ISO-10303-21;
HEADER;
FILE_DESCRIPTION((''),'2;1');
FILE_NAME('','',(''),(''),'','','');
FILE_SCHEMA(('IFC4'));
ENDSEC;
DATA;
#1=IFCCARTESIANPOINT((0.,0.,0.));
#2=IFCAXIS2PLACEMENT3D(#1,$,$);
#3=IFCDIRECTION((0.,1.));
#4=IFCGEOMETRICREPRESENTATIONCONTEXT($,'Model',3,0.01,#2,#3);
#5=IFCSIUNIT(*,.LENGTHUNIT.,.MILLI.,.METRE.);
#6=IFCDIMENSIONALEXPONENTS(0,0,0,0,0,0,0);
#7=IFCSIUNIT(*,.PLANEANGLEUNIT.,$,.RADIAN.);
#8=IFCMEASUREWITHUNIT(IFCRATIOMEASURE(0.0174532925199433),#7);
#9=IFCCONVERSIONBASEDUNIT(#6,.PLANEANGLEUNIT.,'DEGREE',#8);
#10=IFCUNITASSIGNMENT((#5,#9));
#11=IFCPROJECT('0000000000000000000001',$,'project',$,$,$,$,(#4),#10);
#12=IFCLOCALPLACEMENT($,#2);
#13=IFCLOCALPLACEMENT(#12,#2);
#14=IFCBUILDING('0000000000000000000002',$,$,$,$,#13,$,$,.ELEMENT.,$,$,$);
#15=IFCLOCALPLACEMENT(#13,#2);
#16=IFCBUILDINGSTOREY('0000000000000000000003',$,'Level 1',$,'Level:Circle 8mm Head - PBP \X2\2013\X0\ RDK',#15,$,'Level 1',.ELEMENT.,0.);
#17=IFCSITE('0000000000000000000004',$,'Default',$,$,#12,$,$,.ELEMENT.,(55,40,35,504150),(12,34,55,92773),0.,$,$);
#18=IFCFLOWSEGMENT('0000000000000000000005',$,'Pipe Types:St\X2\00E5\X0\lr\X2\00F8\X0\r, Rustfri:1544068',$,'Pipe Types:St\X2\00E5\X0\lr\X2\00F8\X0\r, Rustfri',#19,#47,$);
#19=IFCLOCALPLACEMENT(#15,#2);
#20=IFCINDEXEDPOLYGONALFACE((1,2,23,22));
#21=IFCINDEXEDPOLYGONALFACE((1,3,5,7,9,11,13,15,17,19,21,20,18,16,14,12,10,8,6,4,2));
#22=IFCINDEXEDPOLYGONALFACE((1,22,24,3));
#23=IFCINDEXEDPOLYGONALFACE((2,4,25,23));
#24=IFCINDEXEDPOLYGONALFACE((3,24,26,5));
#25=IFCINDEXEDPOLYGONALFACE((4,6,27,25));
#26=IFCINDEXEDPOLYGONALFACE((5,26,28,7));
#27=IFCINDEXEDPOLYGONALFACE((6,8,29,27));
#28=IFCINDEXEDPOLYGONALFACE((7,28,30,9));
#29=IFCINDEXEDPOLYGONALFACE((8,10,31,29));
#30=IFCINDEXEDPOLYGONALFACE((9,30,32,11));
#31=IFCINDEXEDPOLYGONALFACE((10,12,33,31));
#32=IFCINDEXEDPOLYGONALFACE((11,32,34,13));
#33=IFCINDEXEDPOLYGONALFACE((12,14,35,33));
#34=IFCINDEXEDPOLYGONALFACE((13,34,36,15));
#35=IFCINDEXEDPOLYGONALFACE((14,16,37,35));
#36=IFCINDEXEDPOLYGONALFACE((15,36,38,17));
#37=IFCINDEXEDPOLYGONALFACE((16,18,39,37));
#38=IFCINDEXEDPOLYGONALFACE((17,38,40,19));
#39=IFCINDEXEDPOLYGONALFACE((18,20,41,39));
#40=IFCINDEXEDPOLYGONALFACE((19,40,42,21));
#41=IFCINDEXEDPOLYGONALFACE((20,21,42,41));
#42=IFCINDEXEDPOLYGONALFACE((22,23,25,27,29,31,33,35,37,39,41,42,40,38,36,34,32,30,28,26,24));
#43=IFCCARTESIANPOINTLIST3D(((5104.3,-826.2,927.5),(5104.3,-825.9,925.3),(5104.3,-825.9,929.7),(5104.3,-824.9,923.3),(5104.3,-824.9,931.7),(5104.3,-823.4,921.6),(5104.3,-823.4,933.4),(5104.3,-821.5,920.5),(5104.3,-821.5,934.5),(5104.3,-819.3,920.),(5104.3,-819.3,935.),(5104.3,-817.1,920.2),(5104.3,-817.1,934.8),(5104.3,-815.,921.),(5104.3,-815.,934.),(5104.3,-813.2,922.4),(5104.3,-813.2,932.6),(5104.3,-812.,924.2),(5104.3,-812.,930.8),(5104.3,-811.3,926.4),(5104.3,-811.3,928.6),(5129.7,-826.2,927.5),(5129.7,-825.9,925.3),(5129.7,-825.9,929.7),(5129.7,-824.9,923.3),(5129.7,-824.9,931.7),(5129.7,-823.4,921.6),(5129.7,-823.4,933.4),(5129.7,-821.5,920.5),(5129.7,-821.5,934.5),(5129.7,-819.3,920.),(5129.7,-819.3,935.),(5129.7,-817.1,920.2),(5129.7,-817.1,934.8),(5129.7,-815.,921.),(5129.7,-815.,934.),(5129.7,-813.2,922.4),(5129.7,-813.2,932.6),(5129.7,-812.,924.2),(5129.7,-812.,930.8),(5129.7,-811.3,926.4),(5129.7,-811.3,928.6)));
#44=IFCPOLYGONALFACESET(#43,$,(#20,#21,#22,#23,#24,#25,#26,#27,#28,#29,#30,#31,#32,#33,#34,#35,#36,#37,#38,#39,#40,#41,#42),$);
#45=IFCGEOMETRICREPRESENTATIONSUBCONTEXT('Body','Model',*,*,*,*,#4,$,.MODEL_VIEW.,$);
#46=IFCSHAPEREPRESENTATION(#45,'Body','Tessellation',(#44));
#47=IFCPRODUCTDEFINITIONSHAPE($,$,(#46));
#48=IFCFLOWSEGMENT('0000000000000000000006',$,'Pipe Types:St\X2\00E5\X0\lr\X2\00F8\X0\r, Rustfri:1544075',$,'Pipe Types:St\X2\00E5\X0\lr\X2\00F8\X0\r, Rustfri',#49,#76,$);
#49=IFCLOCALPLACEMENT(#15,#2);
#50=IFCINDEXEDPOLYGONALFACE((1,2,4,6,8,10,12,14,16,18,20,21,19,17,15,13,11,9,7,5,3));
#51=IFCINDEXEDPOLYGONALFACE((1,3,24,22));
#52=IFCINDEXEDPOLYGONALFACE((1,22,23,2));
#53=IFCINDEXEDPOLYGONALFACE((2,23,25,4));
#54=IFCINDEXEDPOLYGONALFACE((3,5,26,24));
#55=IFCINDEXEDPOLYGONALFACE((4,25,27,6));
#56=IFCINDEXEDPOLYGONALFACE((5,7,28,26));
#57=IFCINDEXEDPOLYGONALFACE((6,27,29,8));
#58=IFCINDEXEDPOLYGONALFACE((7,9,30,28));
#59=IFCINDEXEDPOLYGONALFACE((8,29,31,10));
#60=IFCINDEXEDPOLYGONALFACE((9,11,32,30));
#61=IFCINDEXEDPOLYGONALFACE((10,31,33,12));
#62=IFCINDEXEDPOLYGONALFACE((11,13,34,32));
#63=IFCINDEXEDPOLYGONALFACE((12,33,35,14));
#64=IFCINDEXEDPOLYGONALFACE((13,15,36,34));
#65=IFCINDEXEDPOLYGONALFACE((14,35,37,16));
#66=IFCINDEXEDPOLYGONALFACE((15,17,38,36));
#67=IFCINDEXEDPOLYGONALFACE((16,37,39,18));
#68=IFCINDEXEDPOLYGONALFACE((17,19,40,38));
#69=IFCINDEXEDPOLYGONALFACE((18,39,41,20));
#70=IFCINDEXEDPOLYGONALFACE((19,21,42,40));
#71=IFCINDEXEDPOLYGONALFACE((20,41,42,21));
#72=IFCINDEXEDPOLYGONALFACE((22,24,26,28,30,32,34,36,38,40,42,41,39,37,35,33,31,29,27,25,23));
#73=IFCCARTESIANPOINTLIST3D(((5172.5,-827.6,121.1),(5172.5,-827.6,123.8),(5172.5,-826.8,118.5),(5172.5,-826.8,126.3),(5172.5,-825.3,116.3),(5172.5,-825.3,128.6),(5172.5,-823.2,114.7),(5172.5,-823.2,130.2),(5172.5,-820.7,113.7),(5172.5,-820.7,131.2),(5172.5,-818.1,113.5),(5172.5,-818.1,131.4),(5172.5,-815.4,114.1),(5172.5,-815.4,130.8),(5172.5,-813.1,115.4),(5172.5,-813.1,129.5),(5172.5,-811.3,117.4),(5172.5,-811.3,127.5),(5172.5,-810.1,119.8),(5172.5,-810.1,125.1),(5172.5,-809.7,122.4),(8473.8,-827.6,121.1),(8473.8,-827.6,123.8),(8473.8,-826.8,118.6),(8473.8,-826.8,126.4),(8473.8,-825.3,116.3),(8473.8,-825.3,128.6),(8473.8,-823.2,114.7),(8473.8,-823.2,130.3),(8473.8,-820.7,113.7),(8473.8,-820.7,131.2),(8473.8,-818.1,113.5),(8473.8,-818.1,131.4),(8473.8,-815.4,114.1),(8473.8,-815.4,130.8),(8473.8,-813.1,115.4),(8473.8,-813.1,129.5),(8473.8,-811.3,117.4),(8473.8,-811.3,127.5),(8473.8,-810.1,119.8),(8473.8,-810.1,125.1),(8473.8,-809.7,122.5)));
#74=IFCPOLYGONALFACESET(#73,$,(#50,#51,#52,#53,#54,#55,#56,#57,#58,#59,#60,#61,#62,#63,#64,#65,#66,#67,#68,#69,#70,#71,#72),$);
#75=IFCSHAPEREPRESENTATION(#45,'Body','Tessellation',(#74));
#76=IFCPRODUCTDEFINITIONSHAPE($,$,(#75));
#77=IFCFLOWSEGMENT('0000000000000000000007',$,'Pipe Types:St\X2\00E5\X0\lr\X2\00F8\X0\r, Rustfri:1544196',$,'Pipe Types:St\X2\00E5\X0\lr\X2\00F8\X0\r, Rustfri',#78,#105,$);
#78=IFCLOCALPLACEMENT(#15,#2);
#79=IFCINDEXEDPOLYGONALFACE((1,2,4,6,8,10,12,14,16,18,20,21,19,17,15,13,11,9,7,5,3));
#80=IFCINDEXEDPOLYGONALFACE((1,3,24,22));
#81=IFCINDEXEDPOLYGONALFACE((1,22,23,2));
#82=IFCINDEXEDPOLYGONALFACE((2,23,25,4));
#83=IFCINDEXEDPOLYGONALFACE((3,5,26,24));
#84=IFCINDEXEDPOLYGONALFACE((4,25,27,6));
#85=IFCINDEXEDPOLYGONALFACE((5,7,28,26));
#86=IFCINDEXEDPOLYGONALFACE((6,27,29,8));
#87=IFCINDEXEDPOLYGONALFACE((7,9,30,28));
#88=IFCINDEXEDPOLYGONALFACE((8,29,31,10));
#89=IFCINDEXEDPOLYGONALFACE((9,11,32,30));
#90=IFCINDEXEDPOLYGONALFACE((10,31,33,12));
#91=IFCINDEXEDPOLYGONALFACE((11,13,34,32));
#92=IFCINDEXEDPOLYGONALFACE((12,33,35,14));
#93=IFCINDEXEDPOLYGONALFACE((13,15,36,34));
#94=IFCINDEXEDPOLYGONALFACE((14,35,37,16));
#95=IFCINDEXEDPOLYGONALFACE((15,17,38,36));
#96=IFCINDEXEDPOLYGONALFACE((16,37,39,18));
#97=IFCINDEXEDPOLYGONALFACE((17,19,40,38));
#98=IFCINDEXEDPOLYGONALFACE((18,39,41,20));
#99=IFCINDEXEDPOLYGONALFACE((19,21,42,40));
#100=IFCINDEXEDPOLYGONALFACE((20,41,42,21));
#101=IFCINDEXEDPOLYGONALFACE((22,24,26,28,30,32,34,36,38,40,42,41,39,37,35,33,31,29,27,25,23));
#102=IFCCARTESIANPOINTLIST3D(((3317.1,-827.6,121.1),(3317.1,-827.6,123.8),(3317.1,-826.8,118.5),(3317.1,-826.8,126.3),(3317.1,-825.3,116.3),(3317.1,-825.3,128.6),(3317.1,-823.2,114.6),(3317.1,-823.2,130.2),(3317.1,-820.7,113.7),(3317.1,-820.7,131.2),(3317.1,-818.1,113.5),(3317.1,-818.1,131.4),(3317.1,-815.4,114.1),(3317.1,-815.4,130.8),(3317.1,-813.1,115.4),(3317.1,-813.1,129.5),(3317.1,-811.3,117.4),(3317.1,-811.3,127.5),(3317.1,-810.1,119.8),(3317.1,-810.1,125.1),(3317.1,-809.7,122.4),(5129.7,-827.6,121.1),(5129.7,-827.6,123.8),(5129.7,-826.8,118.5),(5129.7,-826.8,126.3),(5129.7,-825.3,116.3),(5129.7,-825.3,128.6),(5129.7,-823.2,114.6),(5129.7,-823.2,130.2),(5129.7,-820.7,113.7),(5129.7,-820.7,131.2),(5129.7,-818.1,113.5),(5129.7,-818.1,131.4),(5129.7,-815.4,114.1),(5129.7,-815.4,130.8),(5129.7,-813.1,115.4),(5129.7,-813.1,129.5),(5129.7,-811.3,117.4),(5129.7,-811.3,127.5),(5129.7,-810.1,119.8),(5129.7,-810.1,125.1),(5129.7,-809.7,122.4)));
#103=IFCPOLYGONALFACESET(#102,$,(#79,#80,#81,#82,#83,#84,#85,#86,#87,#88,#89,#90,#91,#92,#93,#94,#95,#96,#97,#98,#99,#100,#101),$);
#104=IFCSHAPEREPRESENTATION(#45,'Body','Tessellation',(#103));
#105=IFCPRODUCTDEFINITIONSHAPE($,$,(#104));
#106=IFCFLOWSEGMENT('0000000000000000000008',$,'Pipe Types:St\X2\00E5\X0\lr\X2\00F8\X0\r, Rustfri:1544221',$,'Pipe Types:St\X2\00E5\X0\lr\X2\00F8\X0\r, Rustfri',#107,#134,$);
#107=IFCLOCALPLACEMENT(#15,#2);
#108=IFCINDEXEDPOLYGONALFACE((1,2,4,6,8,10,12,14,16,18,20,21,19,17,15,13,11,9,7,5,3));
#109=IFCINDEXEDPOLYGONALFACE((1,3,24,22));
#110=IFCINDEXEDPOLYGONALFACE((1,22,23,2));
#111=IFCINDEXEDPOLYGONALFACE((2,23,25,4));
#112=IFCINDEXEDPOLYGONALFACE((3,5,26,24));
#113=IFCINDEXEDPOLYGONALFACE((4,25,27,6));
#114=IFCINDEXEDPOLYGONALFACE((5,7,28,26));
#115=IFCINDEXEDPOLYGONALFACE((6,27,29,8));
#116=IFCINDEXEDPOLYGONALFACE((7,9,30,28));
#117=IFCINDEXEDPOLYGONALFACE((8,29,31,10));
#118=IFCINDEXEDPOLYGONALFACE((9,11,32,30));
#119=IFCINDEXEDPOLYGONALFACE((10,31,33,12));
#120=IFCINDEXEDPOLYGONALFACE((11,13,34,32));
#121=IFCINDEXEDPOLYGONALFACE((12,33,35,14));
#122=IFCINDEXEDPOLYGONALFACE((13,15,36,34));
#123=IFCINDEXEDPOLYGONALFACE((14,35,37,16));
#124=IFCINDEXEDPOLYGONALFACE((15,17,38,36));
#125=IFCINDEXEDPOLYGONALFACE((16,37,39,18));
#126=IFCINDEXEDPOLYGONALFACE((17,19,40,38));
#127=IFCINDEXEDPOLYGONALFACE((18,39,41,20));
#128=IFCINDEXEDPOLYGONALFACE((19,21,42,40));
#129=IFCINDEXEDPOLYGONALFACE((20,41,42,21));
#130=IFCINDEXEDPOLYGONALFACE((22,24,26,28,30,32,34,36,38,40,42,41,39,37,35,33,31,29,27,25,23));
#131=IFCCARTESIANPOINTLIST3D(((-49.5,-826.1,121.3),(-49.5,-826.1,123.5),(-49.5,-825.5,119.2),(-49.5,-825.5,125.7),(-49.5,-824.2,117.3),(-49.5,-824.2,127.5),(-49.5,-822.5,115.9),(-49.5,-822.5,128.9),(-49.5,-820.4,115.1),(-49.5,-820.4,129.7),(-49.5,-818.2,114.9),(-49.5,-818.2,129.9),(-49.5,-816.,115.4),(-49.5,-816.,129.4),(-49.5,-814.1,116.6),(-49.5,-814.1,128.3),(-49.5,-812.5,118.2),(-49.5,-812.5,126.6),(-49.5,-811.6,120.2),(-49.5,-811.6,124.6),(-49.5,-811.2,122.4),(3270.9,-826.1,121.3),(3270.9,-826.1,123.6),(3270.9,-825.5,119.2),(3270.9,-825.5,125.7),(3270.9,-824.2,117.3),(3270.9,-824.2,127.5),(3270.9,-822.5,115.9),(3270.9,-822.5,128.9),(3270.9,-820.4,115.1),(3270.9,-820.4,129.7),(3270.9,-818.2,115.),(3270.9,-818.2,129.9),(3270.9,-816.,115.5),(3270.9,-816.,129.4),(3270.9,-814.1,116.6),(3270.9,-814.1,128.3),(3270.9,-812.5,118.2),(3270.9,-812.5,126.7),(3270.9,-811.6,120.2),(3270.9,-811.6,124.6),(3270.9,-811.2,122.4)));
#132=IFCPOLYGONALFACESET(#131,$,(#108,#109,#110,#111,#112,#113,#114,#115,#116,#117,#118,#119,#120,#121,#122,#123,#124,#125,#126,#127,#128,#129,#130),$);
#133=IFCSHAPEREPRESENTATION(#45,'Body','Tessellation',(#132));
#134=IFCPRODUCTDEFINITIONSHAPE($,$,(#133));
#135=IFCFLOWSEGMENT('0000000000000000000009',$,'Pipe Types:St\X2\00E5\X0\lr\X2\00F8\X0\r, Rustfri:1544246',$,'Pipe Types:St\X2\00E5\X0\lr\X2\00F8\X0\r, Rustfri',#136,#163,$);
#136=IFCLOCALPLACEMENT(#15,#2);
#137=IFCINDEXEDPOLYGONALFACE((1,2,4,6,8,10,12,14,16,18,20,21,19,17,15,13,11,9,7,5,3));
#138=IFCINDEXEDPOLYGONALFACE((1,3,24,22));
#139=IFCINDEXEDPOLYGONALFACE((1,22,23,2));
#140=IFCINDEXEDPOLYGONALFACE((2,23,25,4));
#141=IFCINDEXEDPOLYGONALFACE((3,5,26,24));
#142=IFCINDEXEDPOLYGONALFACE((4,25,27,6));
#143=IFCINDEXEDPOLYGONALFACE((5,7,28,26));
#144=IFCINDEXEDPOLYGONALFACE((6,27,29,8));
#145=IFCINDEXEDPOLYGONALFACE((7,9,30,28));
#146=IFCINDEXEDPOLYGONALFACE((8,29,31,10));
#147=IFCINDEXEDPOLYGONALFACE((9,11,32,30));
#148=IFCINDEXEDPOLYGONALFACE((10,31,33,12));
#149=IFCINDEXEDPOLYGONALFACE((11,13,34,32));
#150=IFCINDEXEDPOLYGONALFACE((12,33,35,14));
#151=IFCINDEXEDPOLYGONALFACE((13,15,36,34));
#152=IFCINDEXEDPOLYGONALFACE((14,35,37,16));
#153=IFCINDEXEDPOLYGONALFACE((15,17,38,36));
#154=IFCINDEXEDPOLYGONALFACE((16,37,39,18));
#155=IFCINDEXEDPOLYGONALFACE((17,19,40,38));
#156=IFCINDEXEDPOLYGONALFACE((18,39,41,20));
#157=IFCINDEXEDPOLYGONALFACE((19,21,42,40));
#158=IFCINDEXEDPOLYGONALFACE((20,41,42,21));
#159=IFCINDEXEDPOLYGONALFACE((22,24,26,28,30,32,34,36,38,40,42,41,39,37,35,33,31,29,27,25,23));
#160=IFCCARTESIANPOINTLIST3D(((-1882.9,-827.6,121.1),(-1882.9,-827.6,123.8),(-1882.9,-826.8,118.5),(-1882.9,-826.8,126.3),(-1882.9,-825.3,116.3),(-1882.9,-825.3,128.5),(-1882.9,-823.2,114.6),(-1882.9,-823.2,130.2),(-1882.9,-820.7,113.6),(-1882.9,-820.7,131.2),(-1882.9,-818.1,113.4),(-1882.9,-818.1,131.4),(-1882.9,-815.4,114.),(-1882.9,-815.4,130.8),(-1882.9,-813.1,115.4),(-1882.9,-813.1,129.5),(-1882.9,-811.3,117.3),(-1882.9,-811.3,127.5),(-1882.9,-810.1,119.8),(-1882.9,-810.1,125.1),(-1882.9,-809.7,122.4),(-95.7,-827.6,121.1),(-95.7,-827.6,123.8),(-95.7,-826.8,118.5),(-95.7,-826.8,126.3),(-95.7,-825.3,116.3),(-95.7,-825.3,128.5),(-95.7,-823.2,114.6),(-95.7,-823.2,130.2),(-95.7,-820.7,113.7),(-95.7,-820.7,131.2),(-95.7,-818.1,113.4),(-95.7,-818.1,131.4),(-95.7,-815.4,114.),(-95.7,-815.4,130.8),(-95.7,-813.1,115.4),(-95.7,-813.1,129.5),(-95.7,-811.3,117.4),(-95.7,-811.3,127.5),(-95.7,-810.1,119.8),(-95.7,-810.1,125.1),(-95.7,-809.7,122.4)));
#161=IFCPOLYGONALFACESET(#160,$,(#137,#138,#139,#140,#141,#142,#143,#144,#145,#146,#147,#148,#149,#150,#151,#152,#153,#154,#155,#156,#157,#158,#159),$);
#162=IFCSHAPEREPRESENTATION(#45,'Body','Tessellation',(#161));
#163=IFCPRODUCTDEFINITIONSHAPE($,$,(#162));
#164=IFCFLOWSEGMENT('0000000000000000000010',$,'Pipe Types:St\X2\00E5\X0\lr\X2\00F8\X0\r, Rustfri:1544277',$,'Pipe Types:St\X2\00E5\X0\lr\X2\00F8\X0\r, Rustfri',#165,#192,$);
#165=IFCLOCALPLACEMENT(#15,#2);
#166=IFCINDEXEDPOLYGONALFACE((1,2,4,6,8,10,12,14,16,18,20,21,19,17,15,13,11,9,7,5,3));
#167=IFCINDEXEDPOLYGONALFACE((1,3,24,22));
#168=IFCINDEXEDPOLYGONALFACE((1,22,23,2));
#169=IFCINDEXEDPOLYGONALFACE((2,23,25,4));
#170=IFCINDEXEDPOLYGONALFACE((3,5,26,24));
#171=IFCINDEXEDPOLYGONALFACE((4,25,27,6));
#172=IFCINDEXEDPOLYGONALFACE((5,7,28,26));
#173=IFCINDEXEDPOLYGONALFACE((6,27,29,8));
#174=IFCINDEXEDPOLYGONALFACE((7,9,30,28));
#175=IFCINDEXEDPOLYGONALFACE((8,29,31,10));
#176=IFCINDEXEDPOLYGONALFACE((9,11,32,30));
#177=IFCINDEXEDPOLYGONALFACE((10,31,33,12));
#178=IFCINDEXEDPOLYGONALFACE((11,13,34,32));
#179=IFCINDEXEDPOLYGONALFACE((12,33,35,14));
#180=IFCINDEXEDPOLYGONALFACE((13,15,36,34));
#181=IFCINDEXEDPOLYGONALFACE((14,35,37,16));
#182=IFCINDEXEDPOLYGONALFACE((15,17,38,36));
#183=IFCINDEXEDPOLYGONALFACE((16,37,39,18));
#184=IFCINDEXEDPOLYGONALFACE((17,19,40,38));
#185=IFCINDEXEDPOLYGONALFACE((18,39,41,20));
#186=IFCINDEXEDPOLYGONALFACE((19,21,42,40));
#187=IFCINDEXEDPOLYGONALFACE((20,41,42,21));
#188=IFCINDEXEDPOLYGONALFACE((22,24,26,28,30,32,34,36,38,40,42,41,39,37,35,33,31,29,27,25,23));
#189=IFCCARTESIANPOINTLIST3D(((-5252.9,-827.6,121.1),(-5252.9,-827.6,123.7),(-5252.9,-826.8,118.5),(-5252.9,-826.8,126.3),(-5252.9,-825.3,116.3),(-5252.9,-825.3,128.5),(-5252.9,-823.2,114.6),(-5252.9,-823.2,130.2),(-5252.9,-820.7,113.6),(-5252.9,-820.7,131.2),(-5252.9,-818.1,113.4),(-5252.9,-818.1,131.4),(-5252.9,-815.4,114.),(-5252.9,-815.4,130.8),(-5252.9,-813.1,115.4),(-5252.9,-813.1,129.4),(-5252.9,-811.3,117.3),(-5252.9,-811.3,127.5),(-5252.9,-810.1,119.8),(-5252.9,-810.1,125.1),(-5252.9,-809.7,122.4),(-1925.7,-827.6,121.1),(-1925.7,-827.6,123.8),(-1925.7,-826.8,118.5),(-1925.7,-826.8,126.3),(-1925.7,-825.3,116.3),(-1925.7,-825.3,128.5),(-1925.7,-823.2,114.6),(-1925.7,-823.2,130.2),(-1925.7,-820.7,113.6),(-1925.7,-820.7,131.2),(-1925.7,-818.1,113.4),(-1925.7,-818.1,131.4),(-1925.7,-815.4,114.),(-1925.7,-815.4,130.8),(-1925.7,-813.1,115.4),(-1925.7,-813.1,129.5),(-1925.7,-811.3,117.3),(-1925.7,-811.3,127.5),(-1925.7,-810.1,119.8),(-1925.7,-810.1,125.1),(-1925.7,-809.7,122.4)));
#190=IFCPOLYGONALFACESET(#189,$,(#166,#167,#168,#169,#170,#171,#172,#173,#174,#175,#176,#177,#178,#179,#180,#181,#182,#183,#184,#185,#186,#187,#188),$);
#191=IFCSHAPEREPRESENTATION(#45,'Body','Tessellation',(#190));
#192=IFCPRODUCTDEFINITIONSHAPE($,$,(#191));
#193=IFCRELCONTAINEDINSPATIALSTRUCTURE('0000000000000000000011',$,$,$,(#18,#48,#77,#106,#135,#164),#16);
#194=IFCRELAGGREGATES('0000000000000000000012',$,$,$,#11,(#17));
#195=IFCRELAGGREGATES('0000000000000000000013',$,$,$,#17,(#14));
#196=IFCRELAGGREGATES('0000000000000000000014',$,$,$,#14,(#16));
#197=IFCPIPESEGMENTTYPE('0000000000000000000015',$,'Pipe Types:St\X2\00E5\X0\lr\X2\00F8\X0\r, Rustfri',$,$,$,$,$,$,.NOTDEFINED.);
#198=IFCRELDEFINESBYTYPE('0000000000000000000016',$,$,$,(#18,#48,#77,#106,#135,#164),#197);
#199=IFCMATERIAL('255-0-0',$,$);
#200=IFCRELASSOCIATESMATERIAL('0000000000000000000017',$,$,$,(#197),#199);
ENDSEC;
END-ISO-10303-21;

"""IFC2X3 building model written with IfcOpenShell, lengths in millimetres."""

from ifc_helpers import new_model, entity, si_unit, converted_unit, direction, frame, frame_2d, origin, origin_2d_with_axis, place, context, subcontext, project, spatial, circle, extrude, material, type_object, element, save


model = new_model("IFC2X3")

# Units and contexts
model_context = context("Model", 3, precision=0.01, world=origin(), true_north=direction((0.0, 1.0)))
body_context = subcontext(model_context, "Body", "Model", "MODEL_VIEW")
ifc_project = project(units=[si_unit("LENGTHUNIT", "METRE", prefix="MILLI"), converted_unit("PLANEANGLEUNIT", "DEGREE", entity("IfcRatioMeasure", 0.0174532925199433), si_unit("PLANEANGLEUNIT", "RADIAN"), dimensions=[0, 0, 0, 0, 0, 0, 0])], contexts=[model_context])

# Site, building, storey
site_placement = place(None, origin())
site = spatial("IfcSite", under=ifc_project, at=site_placement, Name="Default", CompositionType="ELEMENT", RefLatitude=(55, 40, 35, 504150), RefLongitude=(12, 34, 55, 92773), RefElevation=0.0)
building_placement = place(site_placement, origin())
building = spatial("IfcBuilding", under=site, at=building_placement, CompositionType="ELEMENT")
storey_placement = place(building_placement, origin())
storey = spatial("IfcBuildingStorey", under=building, at=storey_placement, Name="Level 1", ObjectType="Level:Circle 8mm Head - PBP – RDK", LongName="Level 1", CompositionType="ELEMENT", Elevation=0.0)

# Flow segments
ifc_material_1 = material(Name="255-0-0")
pipe_segment_type = type_object("IfcPipeSegmentType", Name="Pipe Types:Stålrør, Rustfri", PredefinedType="NOTDEFINED", material=ifc_material_1)
flow_segment_1_placement = place(storey_placement, origin())
element("IfcFlowSegment", 1, at=flow_segment_1_placement, inside=storey, type_object=pipe_segment_type, Name="Pipe Types:Stålrør, Rustfri:1544068", ObjectType="Pipe Types:Stålrør, Rustfri", context=body_context, shape_type="SweptSolid", body=[
    extrude(circle(Radius=7.5, at=origin_2d_with_axis()), frame((5104.3, -818.7, 927.5), z_axis=(1.0, 0.0, 0.0), x_axis=(0.0, -1.0, 0.0)), (0.0, 0.0, 1.0), 25.4),
])
flow_segment_2_placement = place(storey_placement, origin())
element("IfcFlowSegment", 2, at=flow_segment_2_placement, inside=storey, type_object=pipe_segment_type, Name="Pipe Types:Stålrør, Rustfri:1544075", ObjectType="Pipe Types:Stålrør, Rustfri", context=body_context, shape_type="SweptSolid", body=[
    extrude(circle(Radius=9.0, at=origin_2d_with_axis()), frame((5172.5, -818.7, 122.4), z_axis=(1.0, 0.0, 0.000004), x_axis=(0.0, 1.0, 0.0)), (0.0, 0.0, 1.0), 3301.3),
])
flow_segment_3_placement = place(storey_placement, origin())
element("IfcFlowSegment", 3, at=flow_segment_3_placement, inside=storey, type_object=pipe_segment_type, Name="Pipe Types:Stålrør, Rustfri:1544196", ObjectType="Pipe Types:Stålrør, Rustfri", context=body_context, shape_type="SweptSolid", body=[
    extrude(circle(Radius=9.0, at=origin_2d_with_axis()), frame((3317.1, -818.7, 122.4), z_axis=(1.0, 0.0, 0.000004), x_axis=(0.0, 1.0, 0.0)), (0.0, 0.0, 1.0), 1812.6),
])
flow_segment_4_placement = place(storey_placement, origin())
element("IfcFlowSegment", 4, at=flow_segment_4_placement, inside=storey, type_object=pipe_segment_type, Name="Pipe Types:Stålrør, Rustfri:1544221", ObjectType="Pipe Types:Stålrør, Rustfri", context=body_context, shape_type="SweptSolid", body=[
    extrude(circle(Radius=7.5, at=frame_2d((0.0, 0.0), x_axis=(1.0, 0.0))), frame((-49.5, -818.7, 122.4), z_axis=(1.0, 0.0, 0.000004), x_axis=(0.0, 1.0, 0.0)), (0.0, 0.0, 1.0), 3320.4),
])
flow_segment_5_placement = place(storey_placement, origin())
element("IfcFlowSegment", 5, at=flow_segment_5_placement, inside=storey, type_object=pipe_segment_type, Name="Pipe Types:Stålrør, Rustfri:1544246", ObjectType="Pipe Types:Stålrør, Rustfri", context=body_context, shape_type="SweptSolid", body=[
    extrude(circle(Radius=9.0, at=frame_2d((0.0, 0.0), x_axis=(1.0, 0.0))), frame((-1882.9, -818.7, 122.4), z_axis=(1.0, 0.0, 0.000004), x_axis=(0.0, 1.0, 0.0)), (0.0, 0.0, 1.0), 1787.2),
])
flow_segment_6_placement = place(storey_placement, origin())
element("IfcFlowSegment", 6, at=flow_segment_6_placement, inside=storey, type_object=pipe_segment_type, Name="Pipe Types:Stålrør, Rustfri:1544277", ObjectType="Pipe Types:Stålrør, Rustfri", context=body_context, shape_type="SweptSolid", body=[
    extrude(circle(Radius=9.0, at=origin_2d_with_axis()), frame((-5252.9, -818.7, 122.4), z_axis=(1.0, 0.0, 0.000004), x_axis=(0.0, 1.0, 0.0)), (0.0, 0.0, 1.0), 3327.2),
])

save(model, "model.ifc")
